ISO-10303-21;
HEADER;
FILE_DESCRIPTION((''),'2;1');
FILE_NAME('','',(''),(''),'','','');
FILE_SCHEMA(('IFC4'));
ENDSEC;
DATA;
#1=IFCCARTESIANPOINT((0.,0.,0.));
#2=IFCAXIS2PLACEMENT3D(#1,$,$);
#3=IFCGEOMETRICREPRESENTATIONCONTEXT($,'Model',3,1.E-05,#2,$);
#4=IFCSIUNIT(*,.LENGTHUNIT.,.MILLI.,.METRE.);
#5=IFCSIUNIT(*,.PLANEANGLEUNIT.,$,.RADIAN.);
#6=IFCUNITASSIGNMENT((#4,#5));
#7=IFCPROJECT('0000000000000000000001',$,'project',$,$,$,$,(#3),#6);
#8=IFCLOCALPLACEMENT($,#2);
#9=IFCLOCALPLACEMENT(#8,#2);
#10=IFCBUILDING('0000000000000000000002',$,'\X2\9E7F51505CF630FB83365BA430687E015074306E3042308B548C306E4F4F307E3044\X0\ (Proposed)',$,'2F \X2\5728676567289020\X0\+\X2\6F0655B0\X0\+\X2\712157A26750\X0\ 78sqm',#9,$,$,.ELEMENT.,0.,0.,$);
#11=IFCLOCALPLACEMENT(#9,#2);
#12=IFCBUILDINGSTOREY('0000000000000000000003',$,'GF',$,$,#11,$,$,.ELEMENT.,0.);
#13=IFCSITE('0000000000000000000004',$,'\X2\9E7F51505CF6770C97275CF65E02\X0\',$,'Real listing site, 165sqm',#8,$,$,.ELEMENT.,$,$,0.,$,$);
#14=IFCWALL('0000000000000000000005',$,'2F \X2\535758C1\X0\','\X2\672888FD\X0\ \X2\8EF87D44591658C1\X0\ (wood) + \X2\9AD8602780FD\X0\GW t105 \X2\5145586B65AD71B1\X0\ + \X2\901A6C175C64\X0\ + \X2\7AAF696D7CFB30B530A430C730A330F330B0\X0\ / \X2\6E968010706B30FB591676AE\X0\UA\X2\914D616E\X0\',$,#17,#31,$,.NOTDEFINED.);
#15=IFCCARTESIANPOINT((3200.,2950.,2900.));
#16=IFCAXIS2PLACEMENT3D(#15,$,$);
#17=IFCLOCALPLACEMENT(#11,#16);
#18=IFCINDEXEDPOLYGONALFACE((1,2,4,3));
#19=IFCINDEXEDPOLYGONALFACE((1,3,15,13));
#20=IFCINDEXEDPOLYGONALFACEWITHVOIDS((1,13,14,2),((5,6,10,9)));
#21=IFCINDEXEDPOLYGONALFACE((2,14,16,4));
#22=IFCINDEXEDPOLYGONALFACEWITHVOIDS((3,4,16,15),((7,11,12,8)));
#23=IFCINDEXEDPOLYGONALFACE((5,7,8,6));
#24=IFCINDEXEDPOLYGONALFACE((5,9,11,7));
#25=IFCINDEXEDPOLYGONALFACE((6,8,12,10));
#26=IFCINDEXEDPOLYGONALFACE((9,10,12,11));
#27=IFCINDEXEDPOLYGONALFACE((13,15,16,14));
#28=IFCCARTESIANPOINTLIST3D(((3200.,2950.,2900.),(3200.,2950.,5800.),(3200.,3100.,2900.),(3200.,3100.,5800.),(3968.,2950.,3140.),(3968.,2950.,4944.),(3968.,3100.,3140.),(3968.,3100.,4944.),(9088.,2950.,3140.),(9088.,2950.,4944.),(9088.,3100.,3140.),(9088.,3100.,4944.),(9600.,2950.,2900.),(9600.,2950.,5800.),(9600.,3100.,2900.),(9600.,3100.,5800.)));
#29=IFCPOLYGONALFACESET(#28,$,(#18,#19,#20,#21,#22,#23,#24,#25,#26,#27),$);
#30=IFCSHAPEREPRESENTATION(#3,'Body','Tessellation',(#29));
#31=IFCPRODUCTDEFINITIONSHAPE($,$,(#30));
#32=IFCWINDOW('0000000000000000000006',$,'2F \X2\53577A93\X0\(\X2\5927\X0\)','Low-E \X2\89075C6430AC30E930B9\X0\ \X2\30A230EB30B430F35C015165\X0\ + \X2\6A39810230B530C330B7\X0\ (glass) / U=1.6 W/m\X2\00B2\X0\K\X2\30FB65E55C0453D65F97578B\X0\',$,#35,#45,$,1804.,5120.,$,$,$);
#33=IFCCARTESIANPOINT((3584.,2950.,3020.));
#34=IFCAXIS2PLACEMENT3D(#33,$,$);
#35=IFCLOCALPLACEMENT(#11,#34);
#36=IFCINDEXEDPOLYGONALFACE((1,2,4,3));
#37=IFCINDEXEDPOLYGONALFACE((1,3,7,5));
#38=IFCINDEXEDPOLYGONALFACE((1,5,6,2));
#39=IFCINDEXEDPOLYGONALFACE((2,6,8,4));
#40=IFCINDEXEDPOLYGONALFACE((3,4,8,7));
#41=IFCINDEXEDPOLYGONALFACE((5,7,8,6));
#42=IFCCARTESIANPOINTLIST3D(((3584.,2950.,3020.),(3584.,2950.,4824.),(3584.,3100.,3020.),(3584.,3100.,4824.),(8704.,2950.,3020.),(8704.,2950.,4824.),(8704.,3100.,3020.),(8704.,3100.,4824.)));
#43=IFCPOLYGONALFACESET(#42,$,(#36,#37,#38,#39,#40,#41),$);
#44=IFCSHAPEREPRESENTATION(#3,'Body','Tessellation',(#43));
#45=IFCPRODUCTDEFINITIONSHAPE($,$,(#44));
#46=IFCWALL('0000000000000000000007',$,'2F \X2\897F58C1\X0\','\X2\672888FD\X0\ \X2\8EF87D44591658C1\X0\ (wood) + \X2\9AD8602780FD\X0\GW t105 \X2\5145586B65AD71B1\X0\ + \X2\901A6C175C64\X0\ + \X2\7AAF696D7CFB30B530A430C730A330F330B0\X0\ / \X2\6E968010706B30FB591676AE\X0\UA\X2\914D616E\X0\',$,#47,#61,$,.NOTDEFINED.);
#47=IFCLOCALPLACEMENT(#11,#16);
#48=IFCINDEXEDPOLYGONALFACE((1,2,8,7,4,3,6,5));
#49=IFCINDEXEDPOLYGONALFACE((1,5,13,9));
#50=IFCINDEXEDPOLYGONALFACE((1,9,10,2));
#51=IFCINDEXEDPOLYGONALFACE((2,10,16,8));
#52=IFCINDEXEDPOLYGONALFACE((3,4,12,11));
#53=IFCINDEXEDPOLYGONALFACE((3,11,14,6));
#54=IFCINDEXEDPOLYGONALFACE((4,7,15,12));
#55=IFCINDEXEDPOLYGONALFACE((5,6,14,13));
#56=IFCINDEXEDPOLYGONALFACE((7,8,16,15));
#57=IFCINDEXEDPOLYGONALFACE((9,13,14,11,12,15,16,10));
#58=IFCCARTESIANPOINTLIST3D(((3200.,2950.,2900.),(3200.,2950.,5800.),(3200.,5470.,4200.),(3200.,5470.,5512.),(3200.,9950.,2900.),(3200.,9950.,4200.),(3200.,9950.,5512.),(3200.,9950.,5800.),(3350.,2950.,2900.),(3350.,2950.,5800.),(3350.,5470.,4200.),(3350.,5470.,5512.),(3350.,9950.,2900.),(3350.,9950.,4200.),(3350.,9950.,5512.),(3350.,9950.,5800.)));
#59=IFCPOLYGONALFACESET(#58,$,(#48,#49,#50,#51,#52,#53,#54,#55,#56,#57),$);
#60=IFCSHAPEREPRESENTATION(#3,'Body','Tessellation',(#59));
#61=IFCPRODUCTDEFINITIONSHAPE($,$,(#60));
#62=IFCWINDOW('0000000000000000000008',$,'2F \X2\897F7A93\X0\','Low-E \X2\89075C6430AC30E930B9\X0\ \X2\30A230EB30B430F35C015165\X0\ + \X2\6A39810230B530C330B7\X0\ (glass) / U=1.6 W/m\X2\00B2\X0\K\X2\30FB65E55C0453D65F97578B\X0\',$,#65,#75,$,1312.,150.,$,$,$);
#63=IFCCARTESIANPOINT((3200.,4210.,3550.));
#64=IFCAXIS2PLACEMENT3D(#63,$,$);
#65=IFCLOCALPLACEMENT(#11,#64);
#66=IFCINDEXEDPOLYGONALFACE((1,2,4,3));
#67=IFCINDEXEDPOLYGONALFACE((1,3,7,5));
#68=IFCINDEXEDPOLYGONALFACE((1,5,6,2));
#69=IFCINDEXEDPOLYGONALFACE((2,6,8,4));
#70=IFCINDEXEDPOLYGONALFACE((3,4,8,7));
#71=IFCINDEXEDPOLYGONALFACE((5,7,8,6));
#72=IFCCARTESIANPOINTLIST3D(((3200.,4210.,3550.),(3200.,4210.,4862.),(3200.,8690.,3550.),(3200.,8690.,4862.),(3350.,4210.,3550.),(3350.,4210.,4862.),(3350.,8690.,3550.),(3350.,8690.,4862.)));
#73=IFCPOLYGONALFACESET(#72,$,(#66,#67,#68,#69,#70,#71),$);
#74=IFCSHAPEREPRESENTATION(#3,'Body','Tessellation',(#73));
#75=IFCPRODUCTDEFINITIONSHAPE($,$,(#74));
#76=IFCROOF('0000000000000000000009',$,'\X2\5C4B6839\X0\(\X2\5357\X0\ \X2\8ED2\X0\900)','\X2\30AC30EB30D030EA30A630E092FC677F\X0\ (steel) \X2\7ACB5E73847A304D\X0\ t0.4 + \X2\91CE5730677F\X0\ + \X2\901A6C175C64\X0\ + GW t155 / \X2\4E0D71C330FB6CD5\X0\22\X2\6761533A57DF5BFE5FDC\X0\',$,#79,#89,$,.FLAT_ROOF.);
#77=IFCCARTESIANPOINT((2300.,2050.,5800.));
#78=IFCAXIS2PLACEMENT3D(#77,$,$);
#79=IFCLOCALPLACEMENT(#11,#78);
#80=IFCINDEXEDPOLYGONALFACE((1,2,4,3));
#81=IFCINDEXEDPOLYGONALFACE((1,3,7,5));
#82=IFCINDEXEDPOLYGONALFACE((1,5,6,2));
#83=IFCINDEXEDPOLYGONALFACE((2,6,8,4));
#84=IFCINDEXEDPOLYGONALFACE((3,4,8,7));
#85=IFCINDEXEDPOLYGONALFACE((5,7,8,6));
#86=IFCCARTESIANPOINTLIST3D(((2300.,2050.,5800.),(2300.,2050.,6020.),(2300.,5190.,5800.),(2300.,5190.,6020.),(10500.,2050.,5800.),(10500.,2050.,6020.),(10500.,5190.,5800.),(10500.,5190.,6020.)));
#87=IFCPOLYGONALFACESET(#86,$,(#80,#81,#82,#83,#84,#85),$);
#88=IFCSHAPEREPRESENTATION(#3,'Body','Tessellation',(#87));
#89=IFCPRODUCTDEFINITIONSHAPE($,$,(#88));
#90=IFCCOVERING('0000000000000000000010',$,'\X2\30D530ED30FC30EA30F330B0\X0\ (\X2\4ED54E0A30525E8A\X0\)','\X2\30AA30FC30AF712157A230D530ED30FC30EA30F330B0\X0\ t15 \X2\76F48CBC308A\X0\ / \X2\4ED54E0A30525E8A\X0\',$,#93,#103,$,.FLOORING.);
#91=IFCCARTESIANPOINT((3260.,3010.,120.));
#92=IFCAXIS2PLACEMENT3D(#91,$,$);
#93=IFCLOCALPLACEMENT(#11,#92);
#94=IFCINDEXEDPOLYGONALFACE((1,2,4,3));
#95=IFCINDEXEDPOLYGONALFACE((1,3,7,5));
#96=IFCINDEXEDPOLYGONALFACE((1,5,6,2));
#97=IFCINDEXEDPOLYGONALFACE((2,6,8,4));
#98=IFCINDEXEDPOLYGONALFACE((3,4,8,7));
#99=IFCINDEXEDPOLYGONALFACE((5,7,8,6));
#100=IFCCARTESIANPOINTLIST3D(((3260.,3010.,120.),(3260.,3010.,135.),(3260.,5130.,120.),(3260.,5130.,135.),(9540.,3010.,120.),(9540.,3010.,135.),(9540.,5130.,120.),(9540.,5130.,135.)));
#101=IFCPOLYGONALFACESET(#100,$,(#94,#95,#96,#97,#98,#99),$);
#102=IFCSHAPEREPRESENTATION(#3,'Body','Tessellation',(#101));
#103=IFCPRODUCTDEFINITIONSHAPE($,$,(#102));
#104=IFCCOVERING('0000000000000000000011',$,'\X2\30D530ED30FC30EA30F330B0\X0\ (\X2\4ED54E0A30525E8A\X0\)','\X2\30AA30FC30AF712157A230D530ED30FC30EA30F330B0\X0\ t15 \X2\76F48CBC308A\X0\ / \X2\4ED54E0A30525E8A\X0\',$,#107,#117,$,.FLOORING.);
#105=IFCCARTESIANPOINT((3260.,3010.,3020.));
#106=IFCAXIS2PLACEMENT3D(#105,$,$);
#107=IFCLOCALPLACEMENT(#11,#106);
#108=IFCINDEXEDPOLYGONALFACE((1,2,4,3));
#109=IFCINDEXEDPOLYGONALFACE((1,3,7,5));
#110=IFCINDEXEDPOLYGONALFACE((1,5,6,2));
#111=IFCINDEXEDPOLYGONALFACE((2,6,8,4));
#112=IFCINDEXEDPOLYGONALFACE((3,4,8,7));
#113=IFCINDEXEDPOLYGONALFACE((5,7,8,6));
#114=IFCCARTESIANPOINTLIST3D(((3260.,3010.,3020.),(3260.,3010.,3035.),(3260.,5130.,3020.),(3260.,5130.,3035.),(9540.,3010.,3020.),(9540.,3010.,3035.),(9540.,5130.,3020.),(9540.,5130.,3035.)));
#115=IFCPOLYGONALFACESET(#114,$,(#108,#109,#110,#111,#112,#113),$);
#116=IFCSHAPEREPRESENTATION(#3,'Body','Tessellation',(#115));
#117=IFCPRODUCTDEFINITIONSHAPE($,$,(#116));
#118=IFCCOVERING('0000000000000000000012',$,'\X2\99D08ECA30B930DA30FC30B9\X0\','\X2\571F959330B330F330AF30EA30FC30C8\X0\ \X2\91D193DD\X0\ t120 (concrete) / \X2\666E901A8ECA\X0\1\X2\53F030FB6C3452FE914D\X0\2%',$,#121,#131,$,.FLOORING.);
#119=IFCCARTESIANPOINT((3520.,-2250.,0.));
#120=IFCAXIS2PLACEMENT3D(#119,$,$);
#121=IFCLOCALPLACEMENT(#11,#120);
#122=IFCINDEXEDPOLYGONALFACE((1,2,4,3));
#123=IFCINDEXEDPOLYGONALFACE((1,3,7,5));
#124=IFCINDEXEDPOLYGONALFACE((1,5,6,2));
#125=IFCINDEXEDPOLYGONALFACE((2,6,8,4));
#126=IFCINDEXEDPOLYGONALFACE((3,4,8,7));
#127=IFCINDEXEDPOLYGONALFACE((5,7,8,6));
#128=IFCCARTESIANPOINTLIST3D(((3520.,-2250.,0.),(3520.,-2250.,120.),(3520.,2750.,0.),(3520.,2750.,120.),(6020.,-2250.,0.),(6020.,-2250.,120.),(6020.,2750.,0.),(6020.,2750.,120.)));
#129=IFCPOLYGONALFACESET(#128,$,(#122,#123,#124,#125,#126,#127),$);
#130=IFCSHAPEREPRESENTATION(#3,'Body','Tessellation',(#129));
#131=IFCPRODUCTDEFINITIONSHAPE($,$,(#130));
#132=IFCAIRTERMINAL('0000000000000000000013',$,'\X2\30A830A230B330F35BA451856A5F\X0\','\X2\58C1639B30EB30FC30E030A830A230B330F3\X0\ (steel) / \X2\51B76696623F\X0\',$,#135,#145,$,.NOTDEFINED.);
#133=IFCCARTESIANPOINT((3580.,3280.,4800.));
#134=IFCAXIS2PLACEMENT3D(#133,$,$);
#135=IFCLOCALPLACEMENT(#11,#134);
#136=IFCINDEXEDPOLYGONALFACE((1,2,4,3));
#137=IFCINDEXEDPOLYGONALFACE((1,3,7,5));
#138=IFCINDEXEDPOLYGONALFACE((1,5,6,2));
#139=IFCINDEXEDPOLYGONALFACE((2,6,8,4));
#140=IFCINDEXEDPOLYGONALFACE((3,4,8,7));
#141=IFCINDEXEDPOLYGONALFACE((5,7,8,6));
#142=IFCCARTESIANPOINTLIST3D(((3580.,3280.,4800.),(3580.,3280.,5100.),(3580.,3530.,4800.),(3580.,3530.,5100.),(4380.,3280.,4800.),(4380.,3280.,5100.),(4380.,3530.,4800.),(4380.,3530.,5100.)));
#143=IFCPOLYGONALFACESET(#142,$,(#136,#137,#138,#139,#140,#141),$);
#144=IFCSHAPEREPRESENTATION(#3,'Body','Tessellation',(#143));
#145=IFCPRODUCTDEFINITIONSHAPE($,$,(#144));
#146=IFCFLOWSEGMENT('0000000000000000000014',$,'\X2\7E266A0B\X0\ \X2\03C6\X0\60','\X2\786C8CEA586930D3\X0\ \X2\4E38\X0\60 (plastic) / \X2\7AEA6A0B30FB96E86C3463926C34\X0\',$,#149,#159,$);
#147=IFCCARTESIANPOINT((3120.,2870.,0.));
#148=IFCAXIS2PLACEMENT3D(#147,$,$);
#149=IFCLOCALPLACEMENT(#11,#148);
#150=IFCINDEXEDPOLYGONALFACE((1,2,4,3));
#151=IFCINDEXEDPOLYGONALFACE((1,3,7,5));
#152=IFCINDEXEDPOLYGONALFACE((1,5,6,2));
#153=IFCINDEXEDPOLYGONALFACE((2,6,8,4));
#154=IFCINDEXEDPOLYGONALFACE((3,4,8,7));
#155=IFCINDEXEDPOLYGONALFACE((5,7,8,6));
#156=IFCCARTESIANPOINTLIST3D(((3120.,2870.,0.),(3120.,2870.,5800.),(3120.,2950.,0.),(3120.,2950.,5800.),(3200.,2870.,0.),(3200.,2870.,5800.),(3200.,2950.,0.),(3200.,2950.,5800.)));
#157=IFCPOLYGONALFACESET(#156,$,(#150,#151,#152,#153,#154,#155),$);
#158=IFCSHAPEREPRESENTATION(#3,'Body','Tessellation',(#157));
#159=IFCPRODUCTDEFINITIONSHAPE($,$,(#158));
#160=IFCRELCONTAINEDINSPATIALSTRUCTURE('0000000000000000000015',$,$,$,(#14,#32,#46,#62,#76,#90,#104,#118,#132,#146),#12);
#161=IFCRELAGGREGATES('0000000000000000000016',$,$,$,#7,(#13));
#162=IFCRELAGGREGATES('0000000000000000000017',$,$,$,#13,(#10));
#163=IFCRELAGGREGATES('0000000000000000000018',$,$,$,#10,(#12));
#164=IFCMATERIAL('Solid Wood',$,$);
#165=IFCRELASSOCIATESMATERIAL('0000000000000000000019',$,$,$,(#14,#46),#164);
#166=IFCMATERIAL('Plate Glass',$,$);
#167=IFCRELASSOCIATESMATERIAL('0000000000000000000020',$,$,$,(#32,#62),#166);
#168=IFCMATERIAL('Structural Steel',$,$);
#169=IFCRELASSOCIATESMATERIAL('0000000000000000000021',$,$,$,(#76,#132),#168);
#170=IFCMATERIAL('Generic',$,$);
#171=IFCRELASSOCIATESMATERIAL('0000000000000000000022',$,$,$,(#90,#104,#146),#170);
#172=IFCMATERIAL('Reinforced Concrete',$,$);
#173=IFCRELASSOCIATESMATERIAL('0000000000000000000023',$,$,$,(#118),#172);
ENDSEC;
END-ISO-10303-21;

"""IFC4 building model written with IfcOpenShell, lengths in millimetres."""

from ifc_helpers import new_model, si_unit, frame, frame_2d, origin, place, context, project, spatial, rectangle, extrude, material, element, fill, save


model = new_model("IFC4")

# Units and contexts
model_context = context("Model", 3, precision=1e-05, world=origin())
ifc_project = project(units=[si_unit("LENGTHUNIT", "METRE", prefix="MILLI"), si_unit("PLANEANGLEUNIT", "RADIAN")], contexts=[model_context])

# Site, building, storey
site_placement = place(None, origin())
site = spatial("IfcSite", under=ifc_project, at=site_placement, Name="鹿児島県霧島市", ObjectType="Real listing site, 165sqm", CompositionType="ELEMENT", RefElevation=0.0)
building_placement = place(site_placement, origin())
building = spatial("IfcBuilding", under=site, at=building_placement, Name="鹿児島・茶室と縁側のある和の住まい (Proposed)", ObjectType="2F 在来木造+漆喰+無垢材 78sqm", CompositionType="ELEMENT", ElevationOfRefHeight=0.0, ElevationOfTerrain=0.0)
storey_placement = place(building_placement, origin())
storey = spatial("IfcBuildingStorey", under=building, at=storey_placement, Name="GF", CompositionType="ELEMENT", Elevation=0.0)

# Shared definitions
ifc_material_1 = material(Name="Solid Wood")

# Shared definitions
ifc_material_2 = material(Name="Reinforced Concrete")

# Shared definitions
ifc_material_3 = material(Name="Plate Glass")

# Walls, openings, windows
wall_1_placement = place(storey_placement, frame((3200.0, 2950.0, 2900.0)))
wall_1 = element("IfcWall", 1, at=wall_1_placement, inside=storey, material=ifc_material_1, Name="2F 南壁", Description="木製 軸組外壁 (wood) + 高性能GW t105 充填断熱 + 通気層 + 窯業系サイディング / 準耐火・外皮UA配慮", PredefinedType="NOTDEFINED", context=model_context, shape_type="SweptSolid", body=[
    extrude(rectangle(XDim=6400.0, YDim=150.0, at=frame_2d((3200.0, 75.0))), frame((3200.0, 2950.0, 2900.0)), (0.0, 0.0, 1.0), 2900.0),
])
opening_1_placement = place(storey_placement, frame((3584.0, 2950.0, 3020.0)))
opening_1 = element("IfcOpeningElement", 2, at=opening_1_placement, cuts=wall_1, PredefinedType="NOTDEFINED", context=model_context, shape_type="SweptSolid", body=[
    extrude(rectangle(XDim=5120.0, YDim=150.0, at=frame_2d((2560.0, 75.0))), frame((3584.0, 2950.0, 3020.0)), (0.0, 0.0, 1.0), 1804.0),
])
window_1_placement = place(storey_placement, frame((3584.0, 2950.0, 3020.0)))
window_1 = element("IfcWindow", 3, at=window_1_placement, inside=storey, material=ifc_material_3, Name="2F 南窓(大)", Description="Low-E 複層ガラス アルゴン封入 + 樹脂サッシ (glass) / U=1.6 W/m²K・日射取得型", OverallHeight=1804.0, OverallWidth=5120.0, context=model_context, shape_type="SweptSolid", body=[
    extrude(rectangle(XDim=5120.0, YDim=150.0, at=frame_2d((2560.0, 75.0))), frame((3584.0, 2950.0, 3020.0)), (0.0, 0.0, 1.0), 1804.0),
])
fill(opening_1, window_1)
wall_2_placement = place(storey_placement, frame((3200.0, 2950.0, 2900.0)))
wall_2 = element("IfcWall", 4, at=wall_2_placement, inside=storey, material=ifc_material_1, Name="2F 西壁", Description="木製 軸組外壁 (wood) + 高性能GW t105 充填断熱 + 通気層 + 窯業系サイディング / 準耐火・外皮UA配慮", PredefinedType="NOTDEFINED", context=model_context, shape_type="SweptSolid", body=[
    extrude(rectangle(XDim=150.0, YDim=7000.0, at=frame_2d((75.0, 3500.0))), frame((3200.0, 2950.0, 2900.0)), (0.0, 0.0, 1.0), 2900.0),
])
opening_2_placement = place(storey_placement, frame((3200.0, 4210.0, 3550.0)))
opening_2 = element("IfcOpeningElement", 5, at=opening_2_placement, cuts=wall_2, PredefinedType="NOTDEFINED", context=model_context, shape_type="SweptSolid", body=[
    extrude(rectangle(XDim=150.0, YDim=4480.0, at=frame_2d((75.0, 2240.0))), frame((3200.0, 4210.0, 3550.0)), (0.0, 0.0, 1.0), 1312.0),
])
window_2_placement = place(storey_placement, frame((3200.0, 4210.0, 3550.0)))
window_2 = element("IfcWindow", 6, at=window_2_placement, inside=storey, material=ifc_material_3, Name="2F 西窓", Description="Low-E 複層ガラス アルゴン封入 + 樹脂サッシ (glass) / U=1.6 W/m²K・日射取得型", OverallHeight=1312.0, OverallWidth=150.0, context=model_context, shape_type="SweptSolid", body=[
    extrude(rectangle(XDim=150.0, YDim=4480.0, at=frame_2d((75.0, 2240.0))), frame((3200.0, 4210.0, 3550.0)), (0.0, 0.0, 1.0), 1312.0),
])
fill(opening_2, window_2)

# Roof
ifc_material_4 = material(Name="Structural Steel")
for number, where, name in (
    (7, (2300.0, 2050.0, 5800.0), "屋根(南 軒900)"),
):
    element("IfcRoof", number, at=place(storey_placement, frame(where)), inside=storey, material=ifc_material_4, Name=name, Description="ガルバリウム鋼板 (steel) 立平葺き t0.4 + 野地板 + 通気層 + GW t155 / 不燃・法22条区域対応", PredefinedType="FLAT_ROOF", context=model_context, shape_type="SweptSolid", body=[
        extrude(rectangle(XDim=8200.0, YDim=3140.0, at=frame_2d((4100.0, 1570.0))), frame((2300.0, 2050.0, 5800.0)), (0.0, 0.0, 1.0), 220.0),
    ])

# Coverings
ifc_material_5 = material(Name="Generic")
covering_1_placement = place(storey_placement, frame((3260.0, 3010.0, 120.0)))
element("IfcCovering", 8, at=covering_1_placement, inside=storey, material=ifc_material_5, Name="フローリング (仕上げ床)", Description="オーク無垢フローリング t15 直貼り / 仕上げ床", PredefinedType="FLOORING", context=model_context, shape_type="SweptSolid", body=[
    extrude(rectangle(XDim=6280.0, YDim=2120.0, at=frame_2d((3140.0, 1060.0))), frame((3260.0, 3010.0, 120.0)), (0.0, 0.0, 1.0), 15.0),
])
covering_2_placement = place(storey_placement, frame((3260.0, 3010.0, 3020.0)))
element("IfcCovering", 9, at=covering_2_placement, inside=storey, material=ifc_material_5, Name="フローリング (仕上げ床)", Description="オーク無垢フローリング t15 直貼り / 仕上げ床", PredefinedType="FLOORING", context=model_context, shape_type="SweptSolid", body=[
    extrude(rectangle(XDim=6280.0, YDim=2120.0, at=frame_2d((3140.0, 1060.0))), frame((3260.0, 3010.0, 3020.0)), (0.0, 0.0, 1.0), 15.0),
])
covering_3_placement = place(storey_placement, frame((3520.0, -2250.0, 0.0)))
element("IfcCovering", 10, at=covering_3_placement, inside=storey, material=ifc_material_2, Name="駐車スペース", Description="土間コンクリート 金鏝 t120 (concrete) / 普通車1台・水勾配2%", PredefinedType="FLOORING", context=model_context, shape_type="SweptSolid", body=[
    extrude(rectangle(XDim=2500.0, YDim=5000.0, at=frame_2d((1250.0, 2500.0))), frame((3520.0, -2250.0, 0.0)), (0.0, 0.0, 1.0), 120.0),
])

# Air terminal
air_terminal_placement = place(storey_placement, frame((3580.0, 3280.0, 4800.0)))
element("IfcAirTerminal", 11, at=air_terminal_placement, inside=storey, material=ifc_material_4, Name="エアコン室内機", Description="壁掛ルームエアコン (steel) / 冷暖房", PredefinedType="NOTDEFINED", context=model_context, shape_type="SweptSolid", body=[
    extrude(rectangle(XDim=800.0, YDim=250.0, at=frame_2d((400.0, 125.0))), frame((3580.0, 3280.0, 4800.0)), (0.0, 0.0, 1.0), 300.0),
])

# Flow segment
flow_segment_1_placement = place(storey_placement, frame((3120.0, 2870.0, 0.0)))
element("IfcFlowSegment", 12, at=flow_segment_1_placement, inside=storey, material=ifc_material_5, Name="縦樋 φ60", Description="硬質塩ビ 丸60 (plastic) / 竪樋・雨水排水", context=model_context, shape_type="SweptSolid", body=[
    extrude(rectangle(XDim=80.0, YDim=80.0, at=frame_2d((40.0, 40.0))), frame((3120.0, 2870.0, 0.0)), (0.0, 0.0, 1.0), 5800.0),
])

save(model, "model.ifc")
